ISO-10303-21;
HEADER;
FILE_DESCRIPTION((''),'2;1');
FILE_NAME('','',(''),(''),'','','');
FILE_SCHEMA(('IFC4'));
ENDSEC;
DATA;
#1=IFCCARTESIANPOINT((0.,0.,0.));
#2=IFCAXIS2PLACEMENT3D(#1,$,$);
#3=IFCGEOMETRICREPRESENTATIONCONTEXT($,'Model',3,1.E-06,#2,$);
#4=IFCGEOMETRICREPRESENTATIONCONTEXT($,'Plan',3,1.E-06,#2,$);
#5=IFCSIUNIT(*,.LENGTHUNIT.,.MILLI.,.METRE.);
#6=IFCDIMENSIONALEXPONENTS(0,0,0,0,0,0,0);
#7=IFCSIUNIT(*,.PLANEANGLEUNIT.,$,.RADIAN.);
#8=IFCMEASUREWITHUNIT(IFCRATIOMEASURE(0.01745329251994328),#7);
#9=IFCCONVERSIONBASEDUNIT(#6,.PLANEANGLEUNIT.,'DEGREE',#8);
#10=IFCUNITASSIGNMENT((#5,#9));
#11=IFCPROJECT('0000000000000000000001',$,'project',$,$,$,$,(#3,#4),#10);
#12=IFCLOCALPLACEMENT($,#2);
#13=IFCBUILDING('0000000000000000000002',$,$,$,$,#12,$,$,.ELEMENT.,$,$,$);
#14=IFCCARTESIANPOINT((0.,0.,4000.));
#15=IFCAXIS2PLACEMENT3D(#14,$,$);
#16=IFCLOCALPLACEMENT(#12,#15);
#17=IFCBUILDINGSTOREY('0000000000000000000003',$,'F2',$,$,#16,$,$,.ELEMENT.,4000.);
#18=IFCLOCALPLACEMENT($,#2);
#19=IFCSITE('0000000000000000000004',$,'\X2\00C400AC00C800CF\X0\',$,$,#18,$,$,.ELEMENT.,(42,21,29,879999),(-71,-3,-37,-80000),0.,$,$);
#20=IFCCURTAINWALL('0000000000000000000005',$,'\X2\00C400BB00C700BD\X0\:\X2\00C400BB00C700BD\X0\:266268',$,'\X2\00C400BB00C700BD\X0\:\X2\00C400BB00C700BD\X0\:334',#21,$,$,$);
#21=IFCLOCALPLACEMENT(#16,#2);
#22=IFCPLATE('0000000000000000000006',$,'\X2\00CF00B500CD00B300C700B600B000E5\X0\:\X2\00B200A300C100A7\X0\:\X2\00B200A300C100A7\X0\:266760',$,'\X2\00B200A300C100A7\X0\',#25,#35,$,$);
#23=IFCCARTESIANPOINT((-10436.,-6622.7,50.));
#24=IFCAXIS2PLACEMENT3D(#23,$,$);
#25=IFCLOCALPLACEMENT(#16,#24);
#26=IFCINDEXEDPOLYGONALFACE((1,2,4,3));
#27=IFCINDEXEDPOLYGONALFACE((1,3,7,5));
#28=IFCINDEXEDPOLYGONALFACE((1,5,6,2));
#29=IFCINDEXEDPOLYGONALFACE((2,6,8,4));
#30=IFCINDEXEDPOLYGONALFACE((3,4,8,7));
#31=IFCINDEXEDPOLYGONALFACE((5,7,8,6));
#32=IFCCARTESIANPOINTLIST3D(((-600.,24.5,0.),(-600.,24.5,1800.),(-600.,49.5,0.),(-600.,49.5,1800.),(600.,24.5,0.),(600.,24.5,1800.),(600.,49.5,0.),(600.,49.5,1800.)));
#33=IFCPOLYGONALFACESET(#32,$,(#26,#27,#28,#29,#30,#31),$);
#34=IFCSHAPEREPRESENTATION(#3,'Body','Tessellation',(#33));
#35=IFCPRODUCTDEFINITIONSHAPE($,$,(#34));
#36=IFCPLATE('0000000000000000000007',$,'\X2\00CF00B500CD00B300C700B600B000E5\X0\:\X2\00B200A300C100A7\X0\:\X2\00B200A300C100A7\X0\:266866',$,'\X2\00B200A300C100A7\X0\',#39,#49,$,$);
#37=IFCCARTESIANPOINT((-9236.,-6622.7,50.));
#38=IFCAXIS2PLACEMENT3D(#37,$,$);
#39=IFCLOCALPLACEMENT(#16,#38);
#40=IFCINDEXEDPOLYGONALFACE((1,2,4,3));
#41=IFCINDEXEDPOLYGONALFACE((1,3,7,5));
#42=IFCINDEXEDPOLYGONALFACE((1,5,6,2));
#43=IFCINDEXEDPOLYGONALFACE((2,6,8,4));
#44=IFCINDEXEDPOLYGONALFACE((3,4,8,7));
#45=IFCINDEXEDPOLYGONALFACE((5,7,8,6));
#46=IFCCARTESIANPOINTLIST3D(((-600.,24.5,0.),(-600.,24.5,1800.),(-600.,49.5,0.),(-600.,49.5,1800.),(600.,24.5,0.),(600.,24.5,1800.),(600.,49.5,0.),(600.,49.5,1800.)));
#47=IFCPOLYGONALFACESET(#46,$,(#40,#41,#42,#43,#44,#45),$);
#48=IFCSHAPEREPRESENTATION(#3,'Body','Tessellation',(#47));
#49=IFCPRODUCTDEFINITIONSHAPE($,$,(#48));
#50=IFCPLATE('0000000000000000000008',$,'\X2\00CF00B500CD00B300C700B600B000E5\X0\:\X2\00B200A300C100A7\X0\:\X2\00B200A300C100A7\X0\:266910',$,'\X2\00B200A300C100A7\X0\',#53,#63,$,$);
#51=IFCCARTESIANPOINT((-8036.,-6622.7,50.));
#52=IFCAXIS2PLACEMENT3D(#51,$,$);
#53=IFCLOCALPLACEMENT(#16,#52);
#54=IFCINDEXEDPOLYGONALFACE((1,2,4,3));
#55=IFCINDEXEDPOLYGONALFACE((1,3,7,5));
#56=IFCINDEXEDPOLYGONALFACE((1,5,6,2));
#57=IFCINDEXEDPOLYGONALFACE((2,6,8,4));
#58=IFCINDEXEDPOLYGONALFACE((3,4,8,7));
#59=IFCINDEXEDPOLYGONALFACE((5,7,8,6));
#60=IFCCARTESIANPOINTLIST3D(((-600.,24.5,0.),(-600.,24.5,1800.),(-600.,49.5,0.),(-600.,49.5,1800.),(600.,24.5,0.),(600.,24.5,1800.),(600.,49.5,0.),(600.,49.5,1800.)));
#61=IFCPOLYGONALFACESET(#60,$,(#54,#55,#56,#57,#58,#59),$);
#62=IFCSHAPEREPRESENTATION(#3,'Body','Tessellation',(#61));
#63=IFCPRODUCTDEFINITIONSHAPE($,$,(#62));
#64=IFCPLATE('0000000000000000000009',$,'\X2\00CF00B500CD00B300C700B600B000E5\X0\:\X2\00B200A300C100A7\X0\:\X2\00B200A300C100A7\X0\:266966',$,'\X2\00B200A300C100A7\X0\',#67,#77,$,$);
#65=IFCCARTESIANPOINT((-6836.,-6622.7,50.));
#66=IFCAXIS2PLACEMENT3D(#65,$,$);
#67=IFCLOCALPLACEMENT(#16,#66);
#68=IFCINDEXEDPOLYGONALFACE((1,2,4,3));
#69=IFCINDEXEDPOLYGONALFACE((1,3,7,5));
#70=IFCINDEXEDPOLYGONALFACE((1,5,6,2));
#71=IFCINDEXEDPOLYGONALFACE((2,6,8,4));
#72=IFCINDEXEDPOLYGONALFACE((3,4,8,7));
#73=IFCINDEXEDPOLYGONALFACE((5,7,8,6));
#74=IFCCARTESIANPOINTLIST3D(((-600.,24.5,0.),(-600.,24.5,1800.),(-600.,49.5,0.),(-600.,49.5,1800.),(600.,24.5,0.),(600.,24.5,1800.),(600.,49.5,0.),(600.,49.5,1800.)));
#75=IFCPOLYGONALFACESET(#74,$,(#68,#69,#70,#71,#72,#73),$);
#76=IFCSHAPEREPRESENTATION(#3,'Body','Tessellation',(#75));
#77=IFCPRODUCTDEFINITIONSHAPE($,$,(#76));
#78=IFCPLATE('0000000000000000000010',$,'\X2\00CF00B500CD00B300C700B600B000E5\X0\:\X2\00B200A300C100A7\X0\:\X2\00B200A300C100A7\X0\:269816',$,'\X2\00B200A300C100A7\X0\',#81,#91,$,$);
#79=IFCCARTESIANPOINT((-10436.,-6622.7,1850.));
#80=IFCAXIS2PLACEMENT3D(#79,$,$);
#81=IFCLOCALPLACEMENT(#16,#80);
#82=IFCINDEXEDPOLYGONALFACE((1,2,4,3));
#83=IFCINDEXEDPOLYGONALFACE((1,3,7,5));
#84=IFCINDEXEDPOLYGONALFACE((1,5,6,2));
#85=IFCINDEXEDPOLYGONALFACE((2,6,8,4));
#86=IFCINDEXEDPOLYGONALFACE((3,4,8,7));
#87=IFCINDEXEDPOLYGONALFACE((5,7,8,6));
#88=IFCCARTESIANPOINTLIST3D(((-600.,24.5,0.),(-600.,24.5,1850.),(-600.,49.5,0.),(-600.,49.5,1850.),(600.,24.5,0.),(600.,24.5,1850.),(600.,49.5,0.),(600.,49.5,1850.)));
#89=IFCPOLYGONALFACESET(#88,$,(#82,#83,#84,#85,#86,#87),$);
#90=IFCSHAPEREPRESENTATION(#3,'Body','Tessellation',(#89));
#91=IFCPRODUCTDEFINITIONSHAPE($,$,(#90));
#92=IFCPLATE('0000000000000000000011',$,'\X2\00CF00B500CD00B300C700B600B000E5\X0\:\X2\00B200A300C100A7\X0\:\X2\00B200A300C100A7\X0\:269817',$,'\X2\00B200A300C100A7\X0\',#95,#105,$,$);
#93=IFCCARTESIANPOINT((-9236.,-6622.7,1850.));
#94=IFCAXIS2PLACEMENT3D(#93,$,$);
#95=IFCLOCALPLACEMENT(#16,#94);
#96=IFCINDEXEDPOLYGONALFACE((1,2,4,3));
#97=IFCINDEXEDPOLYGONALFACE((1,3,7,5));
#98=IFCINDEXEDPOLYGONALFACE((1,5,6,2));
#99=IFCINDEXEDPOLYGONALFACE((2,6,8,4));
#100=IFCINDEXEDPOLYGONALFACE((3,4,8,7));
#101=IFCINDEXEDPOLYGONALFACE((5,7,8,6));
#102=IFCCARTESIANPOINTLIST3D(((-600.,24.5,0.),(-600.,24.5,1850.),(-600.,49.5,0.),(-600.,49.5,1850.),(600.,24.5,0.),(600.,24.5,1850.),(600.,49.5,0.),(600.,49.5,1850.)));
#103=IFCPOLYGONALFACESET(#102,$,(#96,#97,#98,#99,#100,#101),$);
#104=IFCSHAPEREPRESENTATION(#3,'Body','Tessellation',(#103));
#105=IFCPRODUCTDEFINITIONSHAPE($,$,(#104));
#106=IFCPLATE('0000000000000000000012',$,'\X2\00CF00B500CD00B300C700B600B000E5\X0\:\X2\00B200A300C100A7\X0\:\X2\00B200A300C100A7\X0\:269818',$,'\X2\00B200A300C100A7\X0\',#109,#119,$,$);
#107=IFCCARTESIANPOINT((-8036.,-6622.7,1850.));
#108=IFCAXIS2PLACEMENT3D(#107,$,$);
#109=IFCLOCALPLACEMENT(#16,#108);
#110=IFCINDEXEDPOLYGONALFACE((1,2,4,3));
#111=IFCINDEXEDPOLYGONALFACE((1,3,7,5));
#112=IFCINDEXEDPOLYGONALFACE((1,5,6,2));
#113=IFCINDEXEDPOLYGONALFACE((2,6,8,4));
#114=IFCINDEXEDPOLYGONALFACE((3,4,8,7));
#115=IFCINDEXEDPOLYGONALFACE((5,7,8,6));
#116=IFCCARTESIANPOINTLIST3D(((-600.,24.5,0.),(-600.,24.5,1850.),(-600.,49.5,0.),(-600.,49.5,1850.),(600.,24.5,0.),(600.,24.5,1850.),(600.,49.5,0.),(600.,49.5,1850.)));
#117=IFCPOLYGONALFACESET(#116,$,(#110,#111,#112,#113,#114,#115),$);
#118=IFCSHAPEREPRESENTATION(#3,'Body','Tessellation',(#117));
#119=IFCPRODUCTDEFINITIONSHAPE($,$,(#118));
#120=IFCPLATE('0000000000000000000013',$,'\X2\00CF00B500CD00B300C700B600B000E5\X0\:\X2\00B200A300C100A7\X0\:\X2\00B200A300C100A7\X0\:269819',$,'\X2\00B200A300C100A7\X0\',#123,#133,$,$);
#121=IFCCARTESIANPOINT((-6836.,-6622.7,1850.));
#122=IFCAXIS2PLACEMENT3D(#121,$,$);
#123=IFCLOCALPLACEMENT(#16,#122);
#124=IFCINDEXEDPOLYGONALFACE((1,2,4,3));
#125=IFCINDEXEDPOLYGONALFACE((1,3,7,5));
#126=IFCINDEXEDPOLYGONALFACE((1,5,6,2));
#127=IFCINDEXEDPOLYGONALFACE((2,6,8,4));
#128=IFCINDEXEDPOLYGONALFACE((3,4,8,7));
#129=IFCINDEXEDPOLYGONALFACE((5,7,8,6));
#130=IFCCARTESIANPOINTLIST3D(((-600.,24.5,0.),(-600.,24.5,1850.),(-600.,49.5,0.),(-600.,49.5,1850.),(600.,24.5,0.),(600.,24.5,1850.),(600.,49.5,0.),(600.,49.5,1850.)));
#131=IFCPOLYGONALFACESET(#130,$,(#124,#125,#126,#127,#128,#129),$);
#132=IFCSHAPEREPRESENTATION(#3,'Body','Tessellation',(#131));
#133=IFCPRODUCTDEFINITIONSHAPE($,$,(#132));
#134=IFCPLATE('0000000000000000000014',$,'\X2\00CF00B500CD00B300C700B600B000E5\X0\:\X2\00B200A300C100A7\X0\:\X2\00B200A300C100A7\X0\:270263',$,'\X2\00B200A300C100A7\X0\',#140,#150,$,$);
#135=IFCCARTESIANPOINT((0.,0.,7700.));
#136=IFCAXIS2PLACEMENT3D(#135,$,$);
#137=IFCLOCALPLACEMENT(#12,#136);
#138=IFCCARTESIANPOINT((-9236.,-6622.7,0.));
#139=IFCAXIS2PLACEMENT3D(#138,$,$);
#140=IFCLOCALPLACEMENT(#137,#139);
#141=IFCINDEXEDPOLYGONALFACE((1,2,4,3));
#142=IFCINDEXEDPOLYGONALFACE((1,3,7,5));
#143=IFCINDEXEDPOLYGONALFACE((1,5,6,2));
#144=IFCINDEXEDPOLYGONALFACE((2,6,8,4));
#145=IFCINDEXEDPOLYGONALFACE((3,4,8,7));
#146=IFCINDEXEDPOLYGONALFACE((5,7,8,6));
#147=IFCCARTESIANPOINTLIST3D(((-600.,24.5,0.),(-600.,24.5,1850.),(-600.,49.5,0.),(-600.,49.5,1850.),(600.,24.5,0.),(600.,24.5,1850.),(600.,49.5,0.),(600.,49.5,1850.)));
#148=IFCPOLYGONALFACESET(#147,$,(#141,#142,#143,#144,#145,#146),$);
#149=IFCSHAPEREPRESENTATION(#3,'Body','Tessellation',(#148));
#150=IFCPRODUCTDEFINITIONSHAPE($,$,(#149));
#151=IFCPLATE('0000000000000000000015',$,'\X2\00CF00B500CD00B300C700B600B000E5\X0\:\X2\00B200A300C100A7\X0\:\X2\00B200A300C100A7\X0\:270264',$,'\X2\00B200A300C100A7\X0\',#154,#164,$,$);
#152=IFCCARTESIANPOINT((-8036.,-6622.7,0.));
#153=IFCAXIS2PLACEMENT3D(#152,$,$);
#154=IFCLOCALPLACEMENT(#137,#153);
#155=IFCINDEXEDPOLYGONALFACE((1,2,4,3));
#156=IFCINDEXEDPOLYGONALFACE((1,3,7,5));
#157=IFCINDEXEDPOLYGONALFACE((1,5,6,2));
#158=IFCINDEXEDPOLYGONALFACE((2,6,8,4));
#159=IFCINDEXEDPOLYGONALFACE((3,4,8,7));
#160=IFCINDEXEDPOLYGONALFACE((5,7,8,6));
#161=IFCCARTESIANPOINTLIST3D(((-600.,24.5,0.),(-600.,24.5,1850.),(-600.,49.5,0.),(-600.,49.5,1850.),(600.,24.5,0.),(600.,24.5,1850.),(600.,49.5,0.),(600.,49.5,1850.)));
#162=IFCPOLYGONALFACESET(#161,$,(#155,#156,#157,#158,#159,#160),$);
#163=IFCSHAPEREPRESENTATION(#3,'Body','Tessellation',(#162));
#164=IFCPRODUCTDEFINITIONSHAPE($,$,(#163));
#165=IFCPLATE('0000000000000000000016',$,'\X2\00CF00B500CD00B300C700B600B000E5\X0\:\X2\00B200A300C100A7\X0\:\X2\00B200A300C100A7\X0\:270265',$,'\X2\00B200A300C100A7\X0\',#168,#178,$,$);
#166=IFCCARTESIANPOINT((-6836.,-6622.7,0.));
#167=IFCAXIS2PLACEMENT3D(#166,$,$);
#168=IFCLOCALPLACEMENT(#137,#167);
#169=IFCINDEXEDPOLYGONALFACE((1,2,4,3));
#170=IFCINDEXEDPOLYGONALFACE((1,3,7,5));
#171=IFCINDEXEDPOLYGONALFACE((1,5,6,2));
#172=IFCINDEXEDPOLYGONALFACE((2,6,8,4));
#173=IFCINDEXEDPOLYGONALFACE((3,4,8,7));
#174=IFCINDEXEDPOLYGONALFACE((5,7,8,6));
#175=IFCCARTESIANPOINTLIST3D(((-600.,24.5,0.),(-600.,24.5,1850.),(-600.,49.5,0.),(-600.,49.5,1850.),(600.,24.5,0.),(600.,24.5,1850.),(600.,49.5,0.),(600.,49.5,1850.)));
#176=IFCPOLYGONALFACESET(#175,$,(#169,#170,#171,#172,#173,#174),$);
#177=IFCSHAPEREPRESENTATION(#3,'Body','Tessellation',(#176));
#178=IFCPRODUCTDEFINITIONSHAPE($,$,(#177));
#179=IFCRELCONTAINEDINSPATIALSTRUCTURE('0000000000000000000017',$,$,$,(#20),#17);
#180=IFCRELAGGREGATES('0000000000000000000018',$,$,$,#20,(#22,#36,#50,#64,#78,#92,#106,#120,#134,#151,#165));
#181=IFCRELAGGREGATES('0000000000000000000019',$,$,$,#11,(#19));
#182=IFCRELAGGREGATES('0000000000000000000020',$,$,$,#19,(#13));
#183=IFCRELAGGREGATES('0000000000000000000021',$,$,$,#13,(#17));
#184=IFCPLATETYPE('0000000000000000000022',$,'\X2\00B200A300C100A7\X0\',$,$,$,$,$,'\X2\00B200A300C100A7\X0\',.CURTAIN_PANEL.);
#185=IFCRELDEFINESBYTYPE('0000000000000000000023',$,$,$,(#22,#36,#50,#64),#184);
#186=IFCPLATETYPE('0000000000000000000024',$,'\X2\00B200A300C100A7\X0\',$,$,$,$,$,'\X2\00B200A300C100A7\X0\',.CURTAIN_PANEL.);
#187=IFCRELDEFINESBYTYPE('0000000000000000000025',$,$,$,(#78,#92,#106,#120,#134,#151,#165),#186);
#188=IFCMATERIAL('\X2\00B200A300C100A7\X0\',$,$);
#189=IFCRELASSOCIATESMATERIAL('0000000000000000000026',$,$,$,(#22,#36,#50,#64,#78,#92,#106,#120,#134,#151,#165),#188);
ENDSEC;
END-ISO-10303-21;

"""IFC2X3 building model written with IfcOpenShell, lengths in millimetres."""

from ifc_helpers import new_model, entity, si_unit, converted_unit, frame, origin, origin_2d_with_axis, place, context, project, spatial, rectangle, extrude, source, transform, mapped, material, type_object, type_shapes, element, aggregate, save


model = new_model("IFC2X3")

# Units and contexts
model_context = context("Model", 3, precision=1e-06, world=origin())
plan_context = context("Plan", 3, precision=1e-06, world=origin())
ifc_project = project(units=[si_unit("LENGTHUNIT", "METRE", prefix="MILLI"), converted_unit("PLANEANGLEUNIT", "DEGREE", entity("IfcRatioMeasure", 0.01745329251994328), si_unit("PLANEANGLEUNIT", "RADIAN"), dimensions=[0, 0, 0, 0, 0, 0, 0])], contexts=[model_context, plan_context])

# Site, building, storey
site_placement = place(None, origin())
site = spatial("IfcSite", under=ifc_project, at=site_placement, Name="Ä¬ÈÏ", CompositionType="ELEMENT", RefLatitude=(42, 21, 29, 879999), RefLongitude=(-71, -3, -37, -80000), RefElevation=0.0)
building_placement = place(None, origin())
building = spatial("IfcBuilding", under=site, at=building_placement, CompositionType="ELEMENT")
storey_placement = place(building_placement, frame((0.0, 0.0, 4000.0)))
storey = spatial("IfcBuildingStorey", under=building, at=storey_placement, Name="F2", CompositionType="ELEMENT", Elevation=4000.0)

# Curtain wall, plates
curtain_wall_placement = place(storey_placement, origin())
curtain_wall = element("IfcCurtainWall", 1, at=curtain_wall_placement, inside=storey, Name="Ä»Ç½:Ä»Ç½:266268", ObjectType="Ä»Ç½:Ä»Ç½:334")
placement = place(building_placement, frame((0.0, 0.0, 7700.0)))
ifc_material_1 = material(Name="²£Á§")
plate_type_1 = type_object("IfcPlateType", Name="²£Á§", ElementType="²£Á§", PredefinedType="CURTAIN_PANEL")
shared_shape_1 = source(origin(), model_context, "Body", "SweptSolid", [
    extrude(rectangle(XDim=25.0, YDim=1200.0, at=origin_2d_with_axis()), frame((0.0, 37.0, 0.0), z_axis=(0.0, 0.0, 1.0), x_axis=(0.0, 1.0, 0.0)), (0.0, 0.0, 1.0), 1800.0),
])
type_shapes(plate_type_1, [shared_shape_1])
plate_1_placement = place(storey_placement, frame((-10436.0, -6622.7, 50.0)))
plate_1 = element("IfcPlate", 2, at=plate_1_placement, type_object=plate_type_1, material=ifc_material_1, Name="ÏµÍ³Ç¶°å:²£Á§:²£Á§:266760", ObjectType="²£Á§", context=model_context, shape_type="MappedRepresentation", body=[
    mapped(shared_shape_1, transform((0.0, 0.0, 0.0), scale=1.0)),
])
plate_2_placement = place(storey_placement, frame((-9236.0, -6622.7, 50.0)))
plate_2 = element("IfcPlate", 3, at=plate_2_placement, type_object=plate_type_1, material=ifc_material_1, Name="ÏµÍ³Ç¶°å:²£Á§:²£Á§:266866", ObjectType="²£Á§", context=model_context, shape_type="MappedRepresentation", body=[
    mapped(shared_shape_1, transform((0.0, 0.0, 0.0), scale=1.0)),
])
plate_3_placement = place(storey_placement, frame((-8036.0, -6622.7, 50.0)))
plate_3 = element("IfcPlate", 4, at=plate_3_placement, type_object=plate_type_1, material=ifc_material_1, Name="ÏµÍ³Ç¶°å:²£Á§:²£Á§:266910", ObjectType="²£Á§", context=model_context, shape_type="MappedRepresentation", body=[
    mapped(shared_shape_1, transform((0.0, 0.0, 0.0), scale=1.0)),
])
plate_4_placement = place(storey_placement, frame((-6836.0, -6622.7, 50.0)))
plate_4 = element("IfcPlate", 5, at=plate_4_placement, type_object=plate_type_1, material=ifc_material_1, Name="ÏµÍ³Ç¶°å:²£Á§:²£Á§:266966", ObjectType="²£Á§", context=model_context, shape_type="MappedRepresentation", body=[
    mapped(shared_shape_1, transform((0.0, 0.0, 0.0), scale=1.0)),
])
plate_type_2 = type_object("IfcPlateType", Name="²£Á§", ElementType="²£Á§", PredefinedType="CURTAIN_PANEL")
shared_shape_2 = source(origin(), model_context, "Body", "SweptSolid", [
    extrude(rectangle(XDim=25.0, YDim=1200.0, at=origin_2d_with_axis()), frame((0.0, 37.0, 0.0), z_axis=(0.0, 0.0, 1.0), x_axis=(0.0, 1.0, 0.0)), (0.0, 0.0, 1.0), 1850.0),
])
type_shapes(plate_type_2, [shared_shape_2])
plate_5_placement = place(storey_placement, frame((-10436.0, -6622.7, 1850.0)))
plate_5 = element("IfcPlate", 6, at=plate_5_placement, type_object=plate_type_2, material=ifc_material_1, Name="ÏµÍ³Ç¶°å:²£Á§:²£Á§:269816", ObjectType="²£Á§", context=model_context, shape_type="MappedRepresentation", body=[
    mapped(shared_shape_2, transform((0.0, 0.0, 0.0), scale=1.0)),
])
plate_6_placement = place(storey_placement, frame((-9236.0, -6622.7, 1850.0)))
plate_6 = element("IfcPlate", 7, at=plate_6_placement, type_object=plate_type_2, material=ifc_material_1, Name="ÏµÍ³Ç¶°å:²£Á§:²£Á§:269817", ObjectType="²£Á§", context=model_context, shape_type="MappedRepresentation", body=[
    mapped(shared_shape_2, transform((0.0, 0.0, 0.0), scale=1.0)),
])
plate_7_placement = place(storey_placement, frame((-8036.0, -6622.7, 1850.0)))
plate_7 = element("IfcPlate", 8, at=plate_7_placement, type_object=plate_type_2, material=ifc_material_1, Name="ÏµÍ³Ç¶°å:²£Á§:²£Á§:269818", ObjectType="²£Á§", context=model_context, shape_type="MappedRepresentation", body=[
    mapped(shared_shape_2, transform((0.0, 0.0, 0.0), scale=1.0)),
])
plate_8_placement = place(storey_placement, frame((-6836.0, -6622.7, 1850.0)))
plate_8 = element("IfcPlate", 9, at=plate_8_placement, type_object=plate_type_2, material=ifc_material_1, Name="ÏµÍ³Ç¶°å:²£Á§:²£Á§:269819", ObjectType="²£Á§", context=model_context, shape_type="MappedRepresentation", body=[
    mapped(shared_shape_2, transform((0.0, 0.0, 0.0), scale=1.0)),
])
plate_9_placement = place(placement, frame((-9236.0, -6622.7, 0.0)))
plate_9 = element("IfcPlate", 10, at=plate_9_placement, type_object=plate_type_2, material=ifc_material_1, Name="ÏµÍ³Ç¶°å:²£Á§:²£Á§:270263", ObjectType="²£Á§", context=model_context, shape_type="MappedRepresentation", body=[
    mapped(shared_shape_2, transform((0.0, 0.0, 0.0), scale=1.0)),
])
plate_10_placement = place(placement, frame((-8036.0, -6622.7, 0.0)))
plate_10 = element("IfcPlate", 11, at=plate_10_placement, type_object=plate_type_2, material=ifc_material_1, Name="ÏµÍ³Ç¶°å:²£Á§:²£Á§:270264", ObjectType="²£Á§", context=model_context, shape_type="MappedRepresentation", body=[
    mapped(shared_shape_2, transform((0.0, 0.0, 0.0), scale=1.0)),
])
plate_11_placement = place(placement, frame((-6836.0, -6622.7, 0.0)))
plate_11 = element("IfcPlate", 12, at=plate_11_placement, type_object=plate_type_2, material=ifc_material_1, Name="ÏµÍ³Ç¶°å:²£Á§:²£Á§:270265", ObjectType="²£Á§", context=model_context, shape_type="MappedRepresentation", body=[
    mapped(shared_shape_2, transform((0.0, 0.0, 0.0), scale=1.0)),
])
aggregate(curtain_wall, [plate_1, plate_2, plate_3, plate_4, plate_5, plate_6, plate_7, plate_8, plate_9, plate_10, plate_11])

save(model, "model.ifc")
